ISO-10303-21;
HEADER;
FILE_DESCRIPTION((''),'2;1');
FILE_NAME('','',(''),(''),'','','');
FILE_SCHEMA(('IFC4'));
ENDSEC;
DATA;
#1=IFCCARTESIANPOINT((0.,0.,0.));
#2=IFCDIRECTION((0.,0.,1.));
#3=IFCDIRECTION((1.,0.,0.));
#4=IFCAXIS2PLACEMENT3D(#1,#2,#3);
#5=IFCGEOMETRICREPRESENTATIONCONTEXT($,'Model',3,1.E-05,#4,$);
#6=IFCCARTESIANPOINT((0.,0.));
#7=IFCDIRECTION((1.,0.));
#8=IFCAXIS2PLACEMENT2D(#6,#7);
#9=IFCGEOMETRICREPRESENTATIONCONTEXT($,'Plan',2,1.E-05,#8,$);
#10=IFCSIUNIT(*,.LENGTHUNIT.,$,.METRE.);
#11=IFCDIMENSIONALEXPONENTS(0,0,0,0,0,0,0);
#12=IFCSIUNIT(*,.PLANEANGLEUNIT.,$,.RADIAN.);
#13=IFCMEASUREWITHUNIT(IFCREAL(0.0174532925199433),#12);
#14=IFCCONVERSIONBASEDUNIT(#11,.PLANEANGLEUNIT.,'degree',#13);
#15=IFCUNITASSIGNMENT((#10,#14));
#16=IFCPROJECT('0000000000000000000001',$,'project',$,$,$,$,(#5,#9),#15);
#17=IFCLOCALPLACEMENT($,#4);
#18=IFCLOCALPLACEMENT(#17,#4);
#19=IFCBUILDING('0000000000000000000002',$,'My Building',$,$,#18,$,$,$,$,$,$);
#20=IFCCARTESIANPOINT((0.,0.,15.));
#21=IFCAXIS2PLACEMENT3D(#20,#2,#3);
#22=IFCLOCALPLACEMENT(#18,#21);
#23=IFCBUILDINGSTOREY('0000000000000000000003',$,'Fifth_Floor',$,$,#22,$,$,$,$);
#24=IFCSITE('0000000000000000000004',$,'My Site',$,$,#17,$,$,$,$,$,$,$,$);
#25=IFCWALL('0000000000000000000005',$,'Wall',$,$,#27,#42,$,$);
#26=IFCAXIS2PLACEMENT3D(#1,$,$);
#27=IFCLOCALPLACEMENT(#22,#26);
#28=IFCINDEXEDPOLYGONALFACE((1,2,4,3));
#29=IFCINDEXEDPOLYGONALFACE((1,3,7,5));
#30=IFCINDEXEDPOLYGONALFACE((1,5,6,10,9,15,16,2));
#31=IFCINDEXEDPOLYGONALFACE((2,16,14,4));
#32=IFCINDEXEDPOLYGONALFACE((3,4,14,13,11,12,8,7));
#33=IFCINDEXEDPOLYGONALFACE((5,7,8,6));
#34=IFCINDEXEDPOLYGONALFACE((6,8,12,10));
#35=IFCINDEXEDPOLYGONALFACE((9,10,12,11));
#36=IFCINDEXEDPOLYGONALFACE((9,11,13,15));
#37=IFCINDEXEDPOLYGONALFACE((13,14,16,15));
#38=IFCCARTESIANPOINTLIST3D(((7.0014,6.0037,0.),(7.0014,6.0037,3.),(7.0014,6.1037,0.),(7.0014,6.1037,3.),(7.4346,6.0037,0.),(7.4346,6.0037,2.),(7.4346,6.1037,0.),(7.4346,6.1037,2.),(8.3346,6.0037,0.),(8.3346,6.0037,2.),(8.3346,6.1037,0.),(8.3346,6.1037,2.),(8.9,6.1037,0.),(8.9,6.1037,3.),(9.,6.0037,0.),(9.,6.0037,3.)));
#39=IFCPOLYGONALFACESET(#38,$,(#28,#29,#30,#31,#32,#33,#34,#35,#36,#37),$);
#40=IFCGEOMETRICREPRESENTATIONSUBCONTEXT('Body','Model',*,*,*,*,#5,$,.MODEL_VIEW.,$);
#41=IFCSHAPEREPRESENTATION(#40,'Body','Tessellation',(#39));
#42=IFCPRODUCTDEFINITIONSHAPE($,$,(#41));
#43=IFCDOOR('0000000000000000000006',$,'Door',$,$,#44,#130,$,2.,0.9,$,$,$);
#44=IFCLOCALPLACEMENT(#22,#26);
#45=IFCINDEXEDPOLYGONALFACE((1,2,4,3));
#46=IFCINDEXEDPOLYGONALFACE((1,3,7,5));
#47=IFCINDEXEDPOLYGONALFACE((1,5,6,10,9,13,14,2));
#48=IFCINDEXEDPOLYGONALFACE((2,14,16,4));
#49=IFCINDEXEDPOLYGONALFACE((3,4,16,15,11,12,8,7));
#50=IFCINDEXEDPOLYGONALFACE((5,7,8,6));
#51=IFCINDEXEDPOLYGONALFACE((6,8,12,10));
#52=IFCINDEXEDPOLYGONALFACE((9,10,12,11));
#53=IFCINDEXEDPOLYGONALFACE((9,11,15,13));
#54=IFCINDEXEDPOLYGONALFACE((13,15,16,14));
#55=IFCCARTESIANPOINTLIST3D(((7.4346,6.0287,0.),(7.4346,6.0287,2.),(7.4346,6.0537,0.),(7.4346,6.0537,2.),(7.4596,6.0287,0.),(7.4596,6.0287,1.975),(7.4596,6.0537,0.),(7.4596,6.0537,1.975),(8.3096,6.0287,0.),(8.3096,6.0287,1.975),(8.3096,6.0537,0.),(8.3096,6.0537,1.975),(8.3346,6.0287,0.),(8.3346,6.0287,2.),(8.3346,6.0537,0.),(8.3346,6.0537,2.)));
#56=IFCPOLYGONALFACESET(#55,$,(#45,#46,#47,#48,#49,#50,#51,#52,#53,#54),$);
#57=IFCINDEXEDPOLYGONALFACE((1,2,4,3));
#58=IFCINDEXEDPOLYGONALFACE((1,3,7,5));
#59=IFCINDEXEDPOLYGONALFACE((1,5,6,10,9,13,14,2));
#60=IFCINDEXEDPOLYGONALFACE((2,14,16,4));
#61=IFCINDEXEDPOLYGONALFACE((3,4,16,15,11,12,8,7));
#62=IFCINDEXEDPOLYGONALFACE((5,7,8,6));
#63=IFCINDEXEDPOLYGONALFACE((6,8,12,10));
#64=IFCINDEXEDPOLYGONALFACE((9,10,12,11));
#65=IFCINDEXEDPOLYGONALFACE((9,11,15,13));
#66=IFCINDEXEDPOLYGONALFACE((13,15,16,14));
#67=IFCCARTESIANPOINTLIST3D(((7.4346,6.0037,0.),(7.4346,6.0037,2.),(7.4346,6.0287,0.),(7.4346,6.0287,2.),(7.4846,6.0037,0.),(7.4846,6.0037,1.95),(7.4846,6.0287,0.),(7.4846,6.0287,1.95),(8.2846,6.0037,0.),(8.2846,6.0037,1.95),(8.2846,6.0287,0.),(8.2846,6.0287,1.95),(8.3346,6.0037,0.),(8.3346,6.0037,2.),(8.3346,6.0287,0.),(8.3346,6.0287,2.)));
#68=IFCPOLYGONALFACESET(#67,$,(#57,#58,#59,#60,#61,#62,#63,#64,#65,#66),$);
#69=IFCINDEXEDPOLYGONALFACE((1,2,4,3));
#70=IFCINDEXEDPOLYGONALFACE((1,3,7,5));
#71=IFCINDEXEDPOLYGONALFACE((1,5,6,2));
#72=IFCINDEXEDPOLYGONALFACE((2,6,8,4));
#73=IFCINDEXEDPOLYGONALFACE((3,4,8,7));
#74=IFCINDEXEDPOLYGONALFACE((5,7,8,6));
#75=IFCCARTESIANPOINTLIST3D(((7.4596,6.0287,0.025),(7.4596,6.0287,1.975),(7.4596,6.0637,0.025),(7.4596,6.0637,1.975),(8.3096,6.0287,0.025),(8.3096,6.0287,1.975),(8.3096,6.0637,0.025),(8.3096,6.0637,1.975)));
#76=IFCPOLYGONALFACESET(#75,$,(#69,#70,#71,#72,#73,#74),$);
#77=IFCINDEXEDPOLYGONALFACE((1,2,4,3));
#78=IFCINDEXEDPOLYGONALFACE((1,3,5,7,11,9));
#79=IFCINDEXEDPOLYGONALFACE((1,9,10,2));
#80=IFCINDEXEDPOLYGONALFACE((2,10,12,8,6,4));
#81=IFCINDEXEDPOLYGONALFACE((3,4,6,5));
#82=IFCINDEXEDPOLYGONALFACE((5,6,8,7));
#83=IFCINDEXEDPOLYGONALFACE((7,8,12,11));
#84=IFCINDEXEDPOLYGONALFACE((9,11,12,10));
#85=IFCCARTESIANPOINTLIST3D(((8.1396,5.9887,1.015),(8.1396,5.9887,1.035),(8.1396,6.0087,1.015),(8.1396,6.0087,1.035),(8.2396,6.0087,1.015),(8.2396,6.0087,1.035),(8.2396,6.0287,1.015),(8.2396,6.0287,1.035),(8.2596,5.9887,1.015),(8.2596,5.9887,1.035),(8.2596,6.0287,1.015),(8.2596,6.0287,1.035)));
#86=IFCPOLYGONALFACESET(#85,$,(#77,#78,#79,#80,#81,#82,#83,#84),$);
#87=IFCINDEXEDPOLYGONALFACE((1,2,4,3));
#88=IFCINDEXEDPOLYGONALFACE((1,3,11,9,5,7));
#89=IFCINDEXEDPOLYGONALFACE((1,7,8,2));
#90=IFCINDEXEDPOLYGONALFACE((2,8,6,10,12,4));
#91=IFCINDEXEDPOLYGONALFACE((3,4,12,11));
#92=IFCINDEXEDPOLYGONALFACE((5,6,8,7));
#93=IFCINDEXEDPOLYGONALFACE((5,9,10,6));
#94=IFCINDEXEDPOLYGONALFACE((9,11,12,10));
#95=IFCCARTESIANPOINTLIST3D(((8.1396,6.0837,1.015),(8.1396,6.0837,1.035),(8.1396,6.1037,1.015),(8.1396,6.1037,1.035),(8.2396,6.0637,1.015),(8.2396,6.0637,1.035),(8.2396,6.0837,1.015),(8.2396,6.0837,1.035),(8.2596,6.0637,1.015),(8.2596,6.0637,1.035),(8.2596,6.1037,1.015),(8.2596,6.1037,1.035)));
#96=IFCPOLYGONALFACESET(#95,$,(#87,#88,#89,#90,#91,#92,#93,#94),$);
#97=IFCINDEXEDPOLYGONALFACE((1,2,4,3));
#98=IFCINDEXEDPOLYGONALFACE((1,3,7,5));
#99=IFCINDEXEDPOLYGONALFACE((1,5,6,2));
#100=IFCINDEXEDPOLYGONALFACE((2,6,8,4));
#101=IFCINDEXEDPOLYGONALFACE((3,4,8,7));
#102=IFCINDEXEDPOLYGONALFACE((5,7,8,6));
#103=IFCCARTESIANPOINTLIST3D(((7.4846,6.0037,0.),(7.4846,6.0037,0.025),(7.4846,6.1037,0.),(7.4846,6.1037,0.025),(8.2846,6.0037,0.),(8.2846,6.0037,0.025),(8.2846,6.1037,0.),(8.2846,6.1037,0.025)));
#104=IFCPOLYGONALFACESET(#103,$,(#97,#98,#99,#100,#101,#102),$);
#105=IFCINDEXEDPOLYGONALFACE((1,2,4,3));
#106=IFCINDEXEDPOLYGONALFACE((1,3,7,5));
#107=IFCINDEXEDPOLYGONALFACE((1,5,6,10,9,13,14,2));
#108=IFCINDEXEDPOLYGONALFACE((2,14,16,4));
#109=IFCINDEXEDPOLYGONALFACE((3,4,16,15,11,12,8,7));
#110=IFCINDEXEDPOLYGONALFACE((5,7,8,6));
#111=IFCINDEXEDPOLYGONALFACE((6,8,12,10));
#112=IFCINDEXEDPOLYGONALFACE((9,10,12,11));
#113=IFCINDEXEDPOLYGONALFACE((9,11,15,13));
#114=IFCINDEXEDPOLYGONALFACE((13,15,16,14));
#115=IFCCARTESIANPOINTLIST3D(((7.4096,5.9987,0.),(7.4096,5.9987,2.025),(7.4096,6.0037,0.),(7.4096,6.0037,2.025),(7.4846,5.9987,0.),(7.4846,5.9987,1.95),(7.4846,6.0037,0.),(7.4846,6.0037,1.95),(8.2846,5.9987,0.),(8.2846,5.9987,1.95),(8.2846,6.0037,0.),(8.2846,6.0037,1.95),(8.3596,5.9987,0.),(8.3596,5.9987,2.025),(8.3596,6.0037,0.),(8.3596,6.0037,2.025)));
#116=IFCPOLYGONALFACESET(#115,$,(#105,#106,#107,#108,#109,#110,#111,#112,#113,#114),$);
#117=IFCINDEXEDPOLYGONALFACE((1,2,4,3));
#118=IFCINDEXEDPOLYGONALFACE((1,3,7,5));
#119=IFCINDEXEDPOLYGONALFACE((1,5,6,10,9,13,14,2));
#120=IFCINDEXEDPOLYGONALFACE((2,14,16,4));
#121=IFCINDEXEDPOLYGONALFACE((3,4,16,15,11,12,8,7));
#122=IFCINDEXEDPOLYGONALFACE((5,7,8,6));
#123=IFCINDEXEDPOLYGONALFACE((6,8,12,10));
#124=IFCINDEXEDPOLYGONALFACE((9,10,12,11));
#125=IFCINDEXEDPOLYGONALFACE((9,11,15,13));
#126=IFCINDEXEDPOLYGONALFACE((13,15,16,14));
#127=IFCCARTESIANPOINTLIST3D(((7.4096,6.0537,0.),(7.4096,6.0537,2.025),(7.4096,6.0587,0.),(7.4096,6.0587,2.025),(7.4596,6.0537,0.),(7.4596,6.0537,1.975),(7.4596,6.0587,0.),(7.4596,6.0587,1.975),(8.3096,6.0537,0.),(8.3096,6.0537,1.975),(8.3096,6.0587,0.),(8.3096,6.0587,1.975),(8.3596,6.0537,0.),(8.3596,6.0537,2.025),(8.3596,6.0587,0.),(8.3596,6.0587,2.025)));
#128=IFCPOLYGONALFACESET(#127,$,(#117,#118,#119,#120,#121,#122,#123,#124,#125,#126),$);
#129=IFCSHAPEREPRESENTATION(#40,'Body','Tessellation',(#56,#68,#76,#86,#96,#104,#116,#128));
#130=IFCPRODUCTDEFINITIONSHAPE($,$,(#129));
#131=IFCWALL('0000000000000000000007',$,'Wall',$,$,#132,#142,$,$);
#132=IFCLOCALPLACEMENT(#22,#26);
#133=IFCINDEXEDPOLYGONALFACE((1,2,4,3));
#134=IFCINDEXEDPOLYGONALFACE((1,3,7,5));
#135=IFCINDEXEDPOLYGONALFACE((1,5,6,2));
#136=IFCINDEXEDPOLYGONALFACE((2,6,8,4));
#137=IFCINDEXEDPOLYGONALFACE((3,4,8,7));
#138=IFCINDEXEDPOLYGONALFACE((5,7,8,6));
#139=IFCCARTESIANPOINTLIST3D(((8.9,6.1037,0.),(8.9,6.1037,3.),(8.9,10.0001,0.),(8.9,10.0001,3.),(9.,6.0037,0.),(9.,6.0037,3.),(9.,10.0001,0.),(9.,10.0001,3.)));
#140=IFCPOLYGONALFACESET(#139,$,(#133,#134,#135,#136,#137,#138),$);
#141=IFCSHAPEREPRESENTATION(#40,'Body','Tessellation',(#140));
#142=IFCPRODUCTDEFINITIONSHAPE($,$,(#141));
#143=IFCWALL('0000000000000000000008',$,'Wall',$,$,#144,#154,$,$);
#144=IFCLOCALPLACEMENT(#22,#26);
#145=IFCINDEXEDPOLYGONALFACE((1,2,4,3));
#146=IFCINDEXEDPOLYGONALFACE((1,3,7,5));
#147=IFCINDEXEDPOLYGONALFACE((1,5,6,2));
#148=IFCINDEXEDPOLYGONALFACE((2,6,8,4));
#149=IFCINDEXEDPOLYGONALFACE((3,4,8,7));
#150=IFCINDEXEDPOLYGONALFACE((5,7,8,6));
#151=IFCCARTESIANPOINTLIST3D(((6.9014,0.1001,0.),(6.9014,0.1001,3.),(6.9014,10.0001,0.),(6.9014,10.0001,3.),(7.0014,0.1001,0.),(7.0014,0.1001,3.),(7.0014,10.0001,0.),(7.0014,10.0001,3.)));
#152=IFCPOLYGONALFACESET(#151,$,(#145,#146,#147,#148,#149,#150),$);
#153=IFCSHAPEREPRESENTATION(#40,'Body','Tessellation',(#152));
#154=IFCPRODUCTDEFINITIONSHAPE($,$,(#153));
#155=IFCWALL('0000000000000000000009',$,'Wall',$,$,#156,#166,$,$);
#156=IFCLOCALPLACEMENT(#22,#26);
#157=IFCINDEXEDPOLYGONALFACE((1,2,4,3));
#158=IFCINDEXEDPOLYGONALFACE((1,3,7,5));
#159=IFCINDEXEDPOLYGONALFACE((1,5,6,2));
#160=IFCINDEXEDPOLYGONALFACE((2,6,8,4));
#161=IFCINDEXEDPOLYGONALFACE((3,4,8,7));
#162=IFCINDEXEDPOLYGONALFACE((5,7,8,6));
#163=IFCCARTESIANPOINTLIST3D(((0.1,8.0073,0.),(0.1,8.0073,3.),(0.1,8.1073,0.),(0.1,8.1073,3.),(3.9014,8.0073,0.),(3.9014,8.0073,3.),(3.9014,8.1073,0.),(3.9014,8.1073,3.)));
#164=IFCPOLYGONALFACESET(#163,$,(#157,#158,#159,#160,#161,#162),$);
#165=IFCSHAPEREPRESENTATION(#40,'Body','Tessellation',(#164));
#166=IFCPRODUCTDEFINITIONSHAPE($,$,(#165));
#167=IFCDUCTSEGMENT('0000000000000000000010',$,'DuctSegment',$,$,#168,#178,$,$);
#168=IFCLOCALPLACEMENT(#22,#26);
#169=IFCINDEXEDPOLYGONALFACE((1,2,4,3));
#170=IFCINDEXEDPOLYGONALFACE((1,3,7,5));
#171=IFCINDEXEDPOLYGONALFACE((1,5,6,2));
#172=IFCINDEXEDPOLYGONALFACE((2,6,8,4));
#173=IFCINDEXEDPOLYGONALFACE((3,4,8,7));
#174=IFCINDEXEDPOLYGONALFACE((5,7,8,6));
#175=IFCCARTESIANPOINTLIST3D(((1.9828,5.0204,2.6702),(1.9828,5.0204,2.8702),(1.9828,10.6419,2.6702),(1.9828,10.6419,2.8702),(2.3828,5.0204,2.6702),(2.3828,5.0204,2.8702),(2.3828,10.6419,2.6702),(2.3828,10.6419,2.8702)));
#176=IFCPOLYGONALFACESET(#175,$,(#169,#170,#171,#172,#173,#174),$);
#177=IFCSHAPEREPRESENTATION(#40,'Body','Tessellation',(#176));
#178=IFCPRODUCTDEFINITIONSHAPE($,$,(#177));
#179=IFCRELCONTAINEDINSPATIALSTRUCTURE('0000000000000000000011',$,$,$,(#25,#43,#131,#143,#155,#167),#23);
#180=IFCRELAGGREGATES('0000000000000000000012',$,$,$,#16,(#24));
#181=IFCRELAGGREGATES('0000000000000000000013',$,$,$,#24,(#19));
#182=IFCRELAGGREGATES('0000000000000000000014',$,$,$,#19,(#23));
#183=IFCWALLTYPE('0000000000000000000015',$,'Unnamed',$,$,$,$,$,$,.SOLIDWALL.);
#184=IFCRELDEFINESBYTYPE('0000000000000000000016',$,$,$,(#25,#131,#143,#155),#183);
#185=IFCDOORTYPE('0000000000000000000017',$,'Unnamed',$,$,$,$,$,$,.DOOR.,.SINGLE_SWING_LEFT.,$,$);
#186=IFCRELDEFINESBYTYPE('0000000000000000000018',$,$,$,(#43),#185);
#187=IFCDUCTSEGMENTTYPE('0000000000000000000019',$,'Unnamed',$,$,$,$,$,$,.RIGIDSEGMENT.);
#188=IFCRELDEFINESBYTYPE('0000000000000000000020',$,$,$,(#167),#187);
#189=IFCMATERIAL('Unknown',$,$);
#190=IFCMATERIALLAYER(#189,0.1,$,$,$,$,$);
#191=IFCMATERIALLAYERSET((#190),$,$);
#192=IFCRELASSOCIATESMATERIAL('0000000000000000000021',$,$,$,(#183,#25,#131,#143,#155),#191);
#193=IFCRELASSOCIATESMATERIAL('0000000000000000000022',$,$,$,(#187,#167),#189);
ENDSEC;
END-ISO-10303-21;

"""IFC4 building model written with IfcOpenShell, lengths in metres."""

from ifc_helpers import new_model, entity, si_unit, converted_unit, frame, origin_with_axes, origin_2d_with_axis, place, context, subcontext, project, spatial, line, indexed_curve, rectangle, outline, extrude, shape, source, transform, mapped, material, layer, layer_set, layer_usage, material_profile, profile_set, profile_usage, type_object, type_shapes, element, fill, save


model = new_model("IFC4")

# Units and contexts
model_context = context("Model", 3, precision=1e-05, world=origin_with_axes())
plan_context = context("Plan", 2, precision=1e-05, world=origin_2d_with_axis())
body_context_1 = subcontext(model_context, "Body", "Model", "MODEL_VIEW")
body_context_2 = subcontext(plan_context, "Body", "Plan", "PLAN_VIEW")
ifc_project = project(units=[si_unit("LENGTHUNIT", "METRE"), converted_unit("PLANEANGLEUNIT", "degree", entity("IfcReal", 0.0174532925199433), si_unit("PLANEANGLEUNIT", "RADIAN"), dimensions=[0, 0, 0, 0, 0, 0, 0])], contexts=[model_context, plan_context])

# Site, building, storey
site_placement = place(None, origin_with_axes())
site = spatial("IfcSite", under=ifc_project, at=site_placement, Name="My Site")
building_placement = place(site_placement, origin_with_axes())
building = spatial("IfcBuilding", under=site, at=building_placement, Name="My Building")
storey_placement = place(building_placement, frame((0.0, 0.0, 15.0), z_axis=(0.0, 0.0, 1.0), x_axis=(1.0, 0.0, 0.0)))
storey = spatial("IfcBuildingStorey", under=building, at=storey_placement, Name="Fifth_Floor")

# Shared definitions
ifc_material = material(Name="Unknown")
ifc_layer = layer(ifc_material, 0.1)
ifc_layer_set = layer_set([ifc_layer])
wall_type = type_object("IfcWallType", Name="Unnamed", PredefinedType="SOLIDWALL", material=ifc_layer_set)
shared_shape_1 = source(origin_with_axes(), body_context_1, "Body", "SweptSolid", [
    extrude(outline(indexed_curve([(0.0, 0.0), (0.9, 0.0), (0.9, 2.0), (0.0, 2.0)], segments=[line(1, 2, 3, 4, 1)])), frame((0.0, -0.6, 0.0), z_axis=(0.0, -1.0, 0.0), x_axis=(1.0, 0.0, 0.0)), (0.0, 0.0, -1.0), 1.2),
])
door_type = type_object("IfcDoorType", Name="Unnamed", OperationType="SINGLE_SWING_LEFT", PredefinedType="DOOR")
shared_shape_2 = source(origin_with_axes(), body_context_1, "Body", "SweptSolid", [
    extrude(outline(indexed_curve([(0.0, 0.0), (0.0, 2.0), (0.9, 2.0), (0.9, 0.0), (0.875, 0.0), (0.875, 1.975), (0.025, 1.975), (0.025, 0.0)], segments=[line(1, 2, 3, 4, 5, 6, 7, 8, 1)])), frame((0.0, 0.025, 0.0), z_axis=(0.0, -1.0, 0.0), x_axis=(1.0, 0.0, 0.0)), (0.0, 0.0, -1.0), 0.025),
    extrude(outline(indexed_curve([(0.0, 0.0), (0.0, 2.0), (0.9, 2.0), (0.9, 0.0), (0.85, 0.0), (0.85, 1.95), (0.05, 1.95), (0.05, 0.0)], segments=[line(1, 2, 3, 4, 5, 6, 7, 8, 1)])), frame((0.0, 0.0, 0.0), z_axis=(0.0, -1.0, 0.0), x_axis=(1.0, 0.0, 0.0)), (0.0, 0.0, -1.0), 0.025),
    extrude(outline(indexed_curve([(0.0, 0.0), (0.85, 0.0), (0.85, 0.035), (0.0, 0.035)], segments=[line(1, 2, 3, 4, 1)])), frame((0.025, 0.025, 0.025), z_axis=(0.0, 0.0, 1.0), x_axis=(1.0, 0.0, 0.0)), (0.0, 0.0, 1.0), 1.95),
    extrude(outline(indexed_curve([(0.0, 0.0), (0.0, -0.04), (-0.12, -0.04), (-0.12, -0.02), (-0.02, -0.02), (-0.02, 0.0)], segments=[line(1, 2, 3, 4, 5, 6, 1)])), frame((0.825, 0.025, 1.015), z_axis=(0.0, 0.0, 1.0), x_axis=(1.0, 0.0, 0.0)), (0.0, 0.0, 1.0), 0.02),
    extrude(outline(indexed_curve([(0.0, 0.0), (0.0, 0.04), (-0.12, 0.04), (-0.12, 0.02), (-0.02, 0.02), (-0.02, 0.0)], segments=[line(1, 2, 3, 4, 5, 6, 1)])), frame((0.825, 0.06, 1.015), z_axis=(0.0, 0.0, 1.0), x_axis=(1.0, 0.0, 0.0)), (0.0, 0.0, 1.0), 0.02),
    extrude(outline(indexed_curve([(0.0, 0.0), (0.8, 0.0), (0.8, 0.1), (0.0, 0.1)], segments=[line(1, 2, 3, 4, 1)])), frame((0.05, 0.0, 0.0), z_axis=(0.0, 0.0, 1.0), x_axis=(1.0, 0.0, 0.0)), (0.0, 0.0, 1.0), 0.025),
    extrude(outline(indexed_curve([(0.0, 0.0), (0.0, 2.025), (0.95, 2.025), (0.95, 0.0), (0.875, 0.0), (0.875, 1.95), (0.075, 1.95), (0.075, 0.0)], segments=[line(1, 2, 3, 4, 5, 6, 7, 8, 1)])), frame((-0.025, -0.005, 0.0), z_axis=(0.0, -1.0, 0.0), x_axis=(1.0, 0.0, 0.0)), (0.0, 0.0, -1.0), 0.005),
    extrude(outline(indexed_curve([(0.0, 0.0), (0.0, 2.025), (0.95, 2.025), (0.95, 0.0), (0.9, 0.0), (0.9, 1.975), (0.05, 1.975), (0.05, 0.0)], segments=[line(1, 2, 3, 4, 5, 6, 7, 8, 1)])), frame((-0.025, 0.05, 0.0), z_axis=(0.0, -1.0, 0.0), x_axis=(1.0, 0.0, 0.0)), (0.0, 0.0, -1.0), 0.005),
])
shared_shape_3 = source(origin_with_axes(), body_context_2, "Body", "Curve2D", [
    entity("IfcIndexedPolyCurve", entity("IfcCartesianPointList2D", [[0.0, 0.0], [0.0, 0.05], [0.025, 0.05], [0.025, 0.025], [0.05, 0.025], [0.05, 0.0]]), [entity("IfcLineIndex", [1, 2, 3, 4, 5, 6, 1])]),
    entity("IfcIndexedPolyCurve", entity("IfcCartesianPointList2D", [[0.9, 0.0], [0.9, 0.05], [0.875, 0.05], [0.875, 0.025], [0.85, 0.025], [0.85, 0.0]]), [entity("IfcLineIndex", [1, 2, 3, 4, 5, 6, 1])]),
    entity("IfcTrimmedCurve", entity("IfcEllipse", entity("IfcAxis2Placement2D", entity("IfcCartesianPoint", [0.06, 0.05]), entity("IfcDirection", [1.0, 0.0])), 0.815, 0.85), [entity("IfcCartesianPoint", [0.875, 0.05])], [entity("IfcCartesianPoint", [0.06, 0.9])], True, "CARTESIAN"),
    entity("IfcIndexedPolyCurve", entity("IfcCartesianPointList2D", [[0.025, 0.05], [0.06, 0.05], [0.06, 0.9], [0.025, 0.9]]), [entity("IfcLineIndex", [1, 2, 3, 4, 1])]),
])
type_shapes(door_type, [shared_shape_2, shared_shape_3])

# Wall, opening, door
ifc_layer_usage_1 = layer_usage(ifc_layer_set, "AXIS2", "POSITIVE", 0.0)
wall_1_placement = place(storey_placement, frame((7.0014, 6.0037, 0.0), z_axis=(0.0, 0.0, 1.0), x_axis=(1.0, 0.0, 0.0)))
wall_1 = element("IfcWall", 1, at=wall_1_placement, inside=storey, type_object=wall_type, material=ifc_layer_usage_1, Name="Wall", context=body_context_1, shape_type="SweptSolid", body=[
    extrude(outline(indexed_curve([(0.0, 0.0), (0.0, 0.1), (1.8986, 0.1), (1.9986, 0.0)], segments=[line(1, 2, 3, 4, 1)])), origin_with_axes(), (0.0, 0.0, 1.0), 3.0),
])
opening_1_placement = place(wall_1_placement, frame((0.4332, 0.0, 0.0), z_axis=(0.0, 0.0, 1.0), x_axis=(1.0, 0.0, 0.0)))
opening_1 = element("IfcOpeningElement", 2, at=opening_1_placement, cuts=wall_1, PredefinedType="OPENING", context=body_context_1, shape_type="MappedRepresentation", body=[
    mapped(shared_shape_1, transform((0.0, 0.0, 0.0), x_axis=(1.0, 0.0, 0.0), y_axis=(0.0, 1.0, 0.0), z_axis=(0.0, 0.0, 1.0), scale=1.0)),
])
door_1_placement = place(opening_1_placement, origin_with_axes())
door_1 = element("IfcDoor", 3, at=door_1_placement, inside=storey, type_object=door_type, Name="Door", OverallHeight=2.0, OverallWidth=0.9, shapes=[
    shape(body_context_1, "Body", "MappedRepresentation", [mapped(shared_shape_2, transform((0.0, 0.0, 0.0), x_axis=(1.0, 0.0, 0.0), y_axis=(0.0, 1.0, 0.0), z_axis=(0.0, 0.0, 1.0), scale=1.0))]),
    shape(body_context_2, "Body", "MappedRepresentation", [mapped(shared_shape_3, transform((0.0, 0.0, 0.0), x_axis=(1.0, 0.0, 0.0), y_axis=(0.0, 1.0, 0.0), z_axis=(0.0, 0.0, 1.0), scale=1.0))]),
])
fill(opening_1, door_1)

# Wall
ifc_layer_usage_2 = layer_usage(ifc_layer_set, "AXIS2", "POSITIVE", 0.0)
wall_2_placement = place(storey_placement, frame((9.0, 6.0037, 0.0), z_axis=(0.0, 0.0, 1.0), x_axis=(0.0, 1.0, 0.0)))
element("IfcWall", 4, at=wall_2_placement, inside=storey, type_object=wall_type, material=ifc_layer_usage_2, Name="Wall", context=body_context_1, shape_type="SweptSolid", body=[
    extrude(outline(indexed_curve([(0.0, 0.0), (0.1, 0.1), (3.9963, 0.1), (3.9963, 0.0)], segments=[line(1, 2, 3, 4, 1)])), origin_with_axes(), (0.0, 0.0, 1.0), 3.0),
])

# Walls
ifc_layer_usage_3 = layer_usage(ifc_layer_set, "AXIS2", "POSITIVE", 0.0)
wall_3_placement = place(storey_placement, frame((6.9014, 10.0001, 0.0), z_axis=(0.0, 0.0, 1.0), x_axis=(0.0, -1.0, 0.0)))
element("IfcWall", 5, at=wall_3_placement, inside=storey, type_object=wall_type, material=ifc_layer_usage_3, Name="Wall", context=body_context_1, shape_type="SweptSolid", body=[
    extrude(outline(indexed_curve([(0.0, 0.0), (0.0, 0.1), (9.9, 0.1), (9.9, 0.0)], segments=[line(1, 2, 3, 4, 1)])), origin_with_axes(), (0.0, 0.0, 1.0), 3.0),
])
ifc_layer_usage_4 = layer_usage(ifc_layer_set, "AXIS2", "POSITIVE", 0.0)
wall_4_placement = place(storey_placement, frame((0.1, 8.0073, 0.0), z_axis=(0.0, 0.0, 1.0), x_axis=(1.0, 0.0, 0.0)))
element("IfcWall", 6, at=wall_4_placement, inside=storey, type_object=wall_type, material=ifc_layer_usage_4, Name="Wall", context=body_context_1, shape_type="SweptSolid", body=[
    extrude(outline(indexed_curve([(0.0, 0.0), (0.0, 0.1), (3.8014, 0.1), (3.8014, 0.0)], segments=[line(1, 2, 3, 4, 1)])), origin_with_axes(), (0.0, 0.0, 1.0), 3.0),
])

# Duct segment
ifc_material_profile_1 = material_profile(ifc_material, rectangle(XDim=0.4, YDim=0.2))
ifc_profile_set_1 = profile_set([ifc_material_profile_1])
ifc_profile_usage_1 = profile_usage(ifc_profile_set_1, cardinal=5)
duct_segment_type = type_object("IfcDuctSegmentType", Name="Unnamed", PredefinedType="RIGIDSEGMENT", material=ifc_profile_set_1)
duct_segment_1_placement = place(storey_placement, frame((2.1828, 10.6419, 2.7702), z_axis=(0.0, -1.0, 0.0), x_axis=(1.0, 0.0, 0.0)))
element("IfcDuctSegment", 7, at=duct_segment_1_placement, inside=storey, type_object=duct_segment_type, material=ifc_profile_usage_1, Name="DuctSegment", context=body_context_1, shape_type="SweptSolid", body=[
    extrude(rectangle(XDim=0.4, YDim=0.2), origin_with_axes(), (0.0, 0.0, 1.0), 5.6215),
])

save(model, "model.ifc")
